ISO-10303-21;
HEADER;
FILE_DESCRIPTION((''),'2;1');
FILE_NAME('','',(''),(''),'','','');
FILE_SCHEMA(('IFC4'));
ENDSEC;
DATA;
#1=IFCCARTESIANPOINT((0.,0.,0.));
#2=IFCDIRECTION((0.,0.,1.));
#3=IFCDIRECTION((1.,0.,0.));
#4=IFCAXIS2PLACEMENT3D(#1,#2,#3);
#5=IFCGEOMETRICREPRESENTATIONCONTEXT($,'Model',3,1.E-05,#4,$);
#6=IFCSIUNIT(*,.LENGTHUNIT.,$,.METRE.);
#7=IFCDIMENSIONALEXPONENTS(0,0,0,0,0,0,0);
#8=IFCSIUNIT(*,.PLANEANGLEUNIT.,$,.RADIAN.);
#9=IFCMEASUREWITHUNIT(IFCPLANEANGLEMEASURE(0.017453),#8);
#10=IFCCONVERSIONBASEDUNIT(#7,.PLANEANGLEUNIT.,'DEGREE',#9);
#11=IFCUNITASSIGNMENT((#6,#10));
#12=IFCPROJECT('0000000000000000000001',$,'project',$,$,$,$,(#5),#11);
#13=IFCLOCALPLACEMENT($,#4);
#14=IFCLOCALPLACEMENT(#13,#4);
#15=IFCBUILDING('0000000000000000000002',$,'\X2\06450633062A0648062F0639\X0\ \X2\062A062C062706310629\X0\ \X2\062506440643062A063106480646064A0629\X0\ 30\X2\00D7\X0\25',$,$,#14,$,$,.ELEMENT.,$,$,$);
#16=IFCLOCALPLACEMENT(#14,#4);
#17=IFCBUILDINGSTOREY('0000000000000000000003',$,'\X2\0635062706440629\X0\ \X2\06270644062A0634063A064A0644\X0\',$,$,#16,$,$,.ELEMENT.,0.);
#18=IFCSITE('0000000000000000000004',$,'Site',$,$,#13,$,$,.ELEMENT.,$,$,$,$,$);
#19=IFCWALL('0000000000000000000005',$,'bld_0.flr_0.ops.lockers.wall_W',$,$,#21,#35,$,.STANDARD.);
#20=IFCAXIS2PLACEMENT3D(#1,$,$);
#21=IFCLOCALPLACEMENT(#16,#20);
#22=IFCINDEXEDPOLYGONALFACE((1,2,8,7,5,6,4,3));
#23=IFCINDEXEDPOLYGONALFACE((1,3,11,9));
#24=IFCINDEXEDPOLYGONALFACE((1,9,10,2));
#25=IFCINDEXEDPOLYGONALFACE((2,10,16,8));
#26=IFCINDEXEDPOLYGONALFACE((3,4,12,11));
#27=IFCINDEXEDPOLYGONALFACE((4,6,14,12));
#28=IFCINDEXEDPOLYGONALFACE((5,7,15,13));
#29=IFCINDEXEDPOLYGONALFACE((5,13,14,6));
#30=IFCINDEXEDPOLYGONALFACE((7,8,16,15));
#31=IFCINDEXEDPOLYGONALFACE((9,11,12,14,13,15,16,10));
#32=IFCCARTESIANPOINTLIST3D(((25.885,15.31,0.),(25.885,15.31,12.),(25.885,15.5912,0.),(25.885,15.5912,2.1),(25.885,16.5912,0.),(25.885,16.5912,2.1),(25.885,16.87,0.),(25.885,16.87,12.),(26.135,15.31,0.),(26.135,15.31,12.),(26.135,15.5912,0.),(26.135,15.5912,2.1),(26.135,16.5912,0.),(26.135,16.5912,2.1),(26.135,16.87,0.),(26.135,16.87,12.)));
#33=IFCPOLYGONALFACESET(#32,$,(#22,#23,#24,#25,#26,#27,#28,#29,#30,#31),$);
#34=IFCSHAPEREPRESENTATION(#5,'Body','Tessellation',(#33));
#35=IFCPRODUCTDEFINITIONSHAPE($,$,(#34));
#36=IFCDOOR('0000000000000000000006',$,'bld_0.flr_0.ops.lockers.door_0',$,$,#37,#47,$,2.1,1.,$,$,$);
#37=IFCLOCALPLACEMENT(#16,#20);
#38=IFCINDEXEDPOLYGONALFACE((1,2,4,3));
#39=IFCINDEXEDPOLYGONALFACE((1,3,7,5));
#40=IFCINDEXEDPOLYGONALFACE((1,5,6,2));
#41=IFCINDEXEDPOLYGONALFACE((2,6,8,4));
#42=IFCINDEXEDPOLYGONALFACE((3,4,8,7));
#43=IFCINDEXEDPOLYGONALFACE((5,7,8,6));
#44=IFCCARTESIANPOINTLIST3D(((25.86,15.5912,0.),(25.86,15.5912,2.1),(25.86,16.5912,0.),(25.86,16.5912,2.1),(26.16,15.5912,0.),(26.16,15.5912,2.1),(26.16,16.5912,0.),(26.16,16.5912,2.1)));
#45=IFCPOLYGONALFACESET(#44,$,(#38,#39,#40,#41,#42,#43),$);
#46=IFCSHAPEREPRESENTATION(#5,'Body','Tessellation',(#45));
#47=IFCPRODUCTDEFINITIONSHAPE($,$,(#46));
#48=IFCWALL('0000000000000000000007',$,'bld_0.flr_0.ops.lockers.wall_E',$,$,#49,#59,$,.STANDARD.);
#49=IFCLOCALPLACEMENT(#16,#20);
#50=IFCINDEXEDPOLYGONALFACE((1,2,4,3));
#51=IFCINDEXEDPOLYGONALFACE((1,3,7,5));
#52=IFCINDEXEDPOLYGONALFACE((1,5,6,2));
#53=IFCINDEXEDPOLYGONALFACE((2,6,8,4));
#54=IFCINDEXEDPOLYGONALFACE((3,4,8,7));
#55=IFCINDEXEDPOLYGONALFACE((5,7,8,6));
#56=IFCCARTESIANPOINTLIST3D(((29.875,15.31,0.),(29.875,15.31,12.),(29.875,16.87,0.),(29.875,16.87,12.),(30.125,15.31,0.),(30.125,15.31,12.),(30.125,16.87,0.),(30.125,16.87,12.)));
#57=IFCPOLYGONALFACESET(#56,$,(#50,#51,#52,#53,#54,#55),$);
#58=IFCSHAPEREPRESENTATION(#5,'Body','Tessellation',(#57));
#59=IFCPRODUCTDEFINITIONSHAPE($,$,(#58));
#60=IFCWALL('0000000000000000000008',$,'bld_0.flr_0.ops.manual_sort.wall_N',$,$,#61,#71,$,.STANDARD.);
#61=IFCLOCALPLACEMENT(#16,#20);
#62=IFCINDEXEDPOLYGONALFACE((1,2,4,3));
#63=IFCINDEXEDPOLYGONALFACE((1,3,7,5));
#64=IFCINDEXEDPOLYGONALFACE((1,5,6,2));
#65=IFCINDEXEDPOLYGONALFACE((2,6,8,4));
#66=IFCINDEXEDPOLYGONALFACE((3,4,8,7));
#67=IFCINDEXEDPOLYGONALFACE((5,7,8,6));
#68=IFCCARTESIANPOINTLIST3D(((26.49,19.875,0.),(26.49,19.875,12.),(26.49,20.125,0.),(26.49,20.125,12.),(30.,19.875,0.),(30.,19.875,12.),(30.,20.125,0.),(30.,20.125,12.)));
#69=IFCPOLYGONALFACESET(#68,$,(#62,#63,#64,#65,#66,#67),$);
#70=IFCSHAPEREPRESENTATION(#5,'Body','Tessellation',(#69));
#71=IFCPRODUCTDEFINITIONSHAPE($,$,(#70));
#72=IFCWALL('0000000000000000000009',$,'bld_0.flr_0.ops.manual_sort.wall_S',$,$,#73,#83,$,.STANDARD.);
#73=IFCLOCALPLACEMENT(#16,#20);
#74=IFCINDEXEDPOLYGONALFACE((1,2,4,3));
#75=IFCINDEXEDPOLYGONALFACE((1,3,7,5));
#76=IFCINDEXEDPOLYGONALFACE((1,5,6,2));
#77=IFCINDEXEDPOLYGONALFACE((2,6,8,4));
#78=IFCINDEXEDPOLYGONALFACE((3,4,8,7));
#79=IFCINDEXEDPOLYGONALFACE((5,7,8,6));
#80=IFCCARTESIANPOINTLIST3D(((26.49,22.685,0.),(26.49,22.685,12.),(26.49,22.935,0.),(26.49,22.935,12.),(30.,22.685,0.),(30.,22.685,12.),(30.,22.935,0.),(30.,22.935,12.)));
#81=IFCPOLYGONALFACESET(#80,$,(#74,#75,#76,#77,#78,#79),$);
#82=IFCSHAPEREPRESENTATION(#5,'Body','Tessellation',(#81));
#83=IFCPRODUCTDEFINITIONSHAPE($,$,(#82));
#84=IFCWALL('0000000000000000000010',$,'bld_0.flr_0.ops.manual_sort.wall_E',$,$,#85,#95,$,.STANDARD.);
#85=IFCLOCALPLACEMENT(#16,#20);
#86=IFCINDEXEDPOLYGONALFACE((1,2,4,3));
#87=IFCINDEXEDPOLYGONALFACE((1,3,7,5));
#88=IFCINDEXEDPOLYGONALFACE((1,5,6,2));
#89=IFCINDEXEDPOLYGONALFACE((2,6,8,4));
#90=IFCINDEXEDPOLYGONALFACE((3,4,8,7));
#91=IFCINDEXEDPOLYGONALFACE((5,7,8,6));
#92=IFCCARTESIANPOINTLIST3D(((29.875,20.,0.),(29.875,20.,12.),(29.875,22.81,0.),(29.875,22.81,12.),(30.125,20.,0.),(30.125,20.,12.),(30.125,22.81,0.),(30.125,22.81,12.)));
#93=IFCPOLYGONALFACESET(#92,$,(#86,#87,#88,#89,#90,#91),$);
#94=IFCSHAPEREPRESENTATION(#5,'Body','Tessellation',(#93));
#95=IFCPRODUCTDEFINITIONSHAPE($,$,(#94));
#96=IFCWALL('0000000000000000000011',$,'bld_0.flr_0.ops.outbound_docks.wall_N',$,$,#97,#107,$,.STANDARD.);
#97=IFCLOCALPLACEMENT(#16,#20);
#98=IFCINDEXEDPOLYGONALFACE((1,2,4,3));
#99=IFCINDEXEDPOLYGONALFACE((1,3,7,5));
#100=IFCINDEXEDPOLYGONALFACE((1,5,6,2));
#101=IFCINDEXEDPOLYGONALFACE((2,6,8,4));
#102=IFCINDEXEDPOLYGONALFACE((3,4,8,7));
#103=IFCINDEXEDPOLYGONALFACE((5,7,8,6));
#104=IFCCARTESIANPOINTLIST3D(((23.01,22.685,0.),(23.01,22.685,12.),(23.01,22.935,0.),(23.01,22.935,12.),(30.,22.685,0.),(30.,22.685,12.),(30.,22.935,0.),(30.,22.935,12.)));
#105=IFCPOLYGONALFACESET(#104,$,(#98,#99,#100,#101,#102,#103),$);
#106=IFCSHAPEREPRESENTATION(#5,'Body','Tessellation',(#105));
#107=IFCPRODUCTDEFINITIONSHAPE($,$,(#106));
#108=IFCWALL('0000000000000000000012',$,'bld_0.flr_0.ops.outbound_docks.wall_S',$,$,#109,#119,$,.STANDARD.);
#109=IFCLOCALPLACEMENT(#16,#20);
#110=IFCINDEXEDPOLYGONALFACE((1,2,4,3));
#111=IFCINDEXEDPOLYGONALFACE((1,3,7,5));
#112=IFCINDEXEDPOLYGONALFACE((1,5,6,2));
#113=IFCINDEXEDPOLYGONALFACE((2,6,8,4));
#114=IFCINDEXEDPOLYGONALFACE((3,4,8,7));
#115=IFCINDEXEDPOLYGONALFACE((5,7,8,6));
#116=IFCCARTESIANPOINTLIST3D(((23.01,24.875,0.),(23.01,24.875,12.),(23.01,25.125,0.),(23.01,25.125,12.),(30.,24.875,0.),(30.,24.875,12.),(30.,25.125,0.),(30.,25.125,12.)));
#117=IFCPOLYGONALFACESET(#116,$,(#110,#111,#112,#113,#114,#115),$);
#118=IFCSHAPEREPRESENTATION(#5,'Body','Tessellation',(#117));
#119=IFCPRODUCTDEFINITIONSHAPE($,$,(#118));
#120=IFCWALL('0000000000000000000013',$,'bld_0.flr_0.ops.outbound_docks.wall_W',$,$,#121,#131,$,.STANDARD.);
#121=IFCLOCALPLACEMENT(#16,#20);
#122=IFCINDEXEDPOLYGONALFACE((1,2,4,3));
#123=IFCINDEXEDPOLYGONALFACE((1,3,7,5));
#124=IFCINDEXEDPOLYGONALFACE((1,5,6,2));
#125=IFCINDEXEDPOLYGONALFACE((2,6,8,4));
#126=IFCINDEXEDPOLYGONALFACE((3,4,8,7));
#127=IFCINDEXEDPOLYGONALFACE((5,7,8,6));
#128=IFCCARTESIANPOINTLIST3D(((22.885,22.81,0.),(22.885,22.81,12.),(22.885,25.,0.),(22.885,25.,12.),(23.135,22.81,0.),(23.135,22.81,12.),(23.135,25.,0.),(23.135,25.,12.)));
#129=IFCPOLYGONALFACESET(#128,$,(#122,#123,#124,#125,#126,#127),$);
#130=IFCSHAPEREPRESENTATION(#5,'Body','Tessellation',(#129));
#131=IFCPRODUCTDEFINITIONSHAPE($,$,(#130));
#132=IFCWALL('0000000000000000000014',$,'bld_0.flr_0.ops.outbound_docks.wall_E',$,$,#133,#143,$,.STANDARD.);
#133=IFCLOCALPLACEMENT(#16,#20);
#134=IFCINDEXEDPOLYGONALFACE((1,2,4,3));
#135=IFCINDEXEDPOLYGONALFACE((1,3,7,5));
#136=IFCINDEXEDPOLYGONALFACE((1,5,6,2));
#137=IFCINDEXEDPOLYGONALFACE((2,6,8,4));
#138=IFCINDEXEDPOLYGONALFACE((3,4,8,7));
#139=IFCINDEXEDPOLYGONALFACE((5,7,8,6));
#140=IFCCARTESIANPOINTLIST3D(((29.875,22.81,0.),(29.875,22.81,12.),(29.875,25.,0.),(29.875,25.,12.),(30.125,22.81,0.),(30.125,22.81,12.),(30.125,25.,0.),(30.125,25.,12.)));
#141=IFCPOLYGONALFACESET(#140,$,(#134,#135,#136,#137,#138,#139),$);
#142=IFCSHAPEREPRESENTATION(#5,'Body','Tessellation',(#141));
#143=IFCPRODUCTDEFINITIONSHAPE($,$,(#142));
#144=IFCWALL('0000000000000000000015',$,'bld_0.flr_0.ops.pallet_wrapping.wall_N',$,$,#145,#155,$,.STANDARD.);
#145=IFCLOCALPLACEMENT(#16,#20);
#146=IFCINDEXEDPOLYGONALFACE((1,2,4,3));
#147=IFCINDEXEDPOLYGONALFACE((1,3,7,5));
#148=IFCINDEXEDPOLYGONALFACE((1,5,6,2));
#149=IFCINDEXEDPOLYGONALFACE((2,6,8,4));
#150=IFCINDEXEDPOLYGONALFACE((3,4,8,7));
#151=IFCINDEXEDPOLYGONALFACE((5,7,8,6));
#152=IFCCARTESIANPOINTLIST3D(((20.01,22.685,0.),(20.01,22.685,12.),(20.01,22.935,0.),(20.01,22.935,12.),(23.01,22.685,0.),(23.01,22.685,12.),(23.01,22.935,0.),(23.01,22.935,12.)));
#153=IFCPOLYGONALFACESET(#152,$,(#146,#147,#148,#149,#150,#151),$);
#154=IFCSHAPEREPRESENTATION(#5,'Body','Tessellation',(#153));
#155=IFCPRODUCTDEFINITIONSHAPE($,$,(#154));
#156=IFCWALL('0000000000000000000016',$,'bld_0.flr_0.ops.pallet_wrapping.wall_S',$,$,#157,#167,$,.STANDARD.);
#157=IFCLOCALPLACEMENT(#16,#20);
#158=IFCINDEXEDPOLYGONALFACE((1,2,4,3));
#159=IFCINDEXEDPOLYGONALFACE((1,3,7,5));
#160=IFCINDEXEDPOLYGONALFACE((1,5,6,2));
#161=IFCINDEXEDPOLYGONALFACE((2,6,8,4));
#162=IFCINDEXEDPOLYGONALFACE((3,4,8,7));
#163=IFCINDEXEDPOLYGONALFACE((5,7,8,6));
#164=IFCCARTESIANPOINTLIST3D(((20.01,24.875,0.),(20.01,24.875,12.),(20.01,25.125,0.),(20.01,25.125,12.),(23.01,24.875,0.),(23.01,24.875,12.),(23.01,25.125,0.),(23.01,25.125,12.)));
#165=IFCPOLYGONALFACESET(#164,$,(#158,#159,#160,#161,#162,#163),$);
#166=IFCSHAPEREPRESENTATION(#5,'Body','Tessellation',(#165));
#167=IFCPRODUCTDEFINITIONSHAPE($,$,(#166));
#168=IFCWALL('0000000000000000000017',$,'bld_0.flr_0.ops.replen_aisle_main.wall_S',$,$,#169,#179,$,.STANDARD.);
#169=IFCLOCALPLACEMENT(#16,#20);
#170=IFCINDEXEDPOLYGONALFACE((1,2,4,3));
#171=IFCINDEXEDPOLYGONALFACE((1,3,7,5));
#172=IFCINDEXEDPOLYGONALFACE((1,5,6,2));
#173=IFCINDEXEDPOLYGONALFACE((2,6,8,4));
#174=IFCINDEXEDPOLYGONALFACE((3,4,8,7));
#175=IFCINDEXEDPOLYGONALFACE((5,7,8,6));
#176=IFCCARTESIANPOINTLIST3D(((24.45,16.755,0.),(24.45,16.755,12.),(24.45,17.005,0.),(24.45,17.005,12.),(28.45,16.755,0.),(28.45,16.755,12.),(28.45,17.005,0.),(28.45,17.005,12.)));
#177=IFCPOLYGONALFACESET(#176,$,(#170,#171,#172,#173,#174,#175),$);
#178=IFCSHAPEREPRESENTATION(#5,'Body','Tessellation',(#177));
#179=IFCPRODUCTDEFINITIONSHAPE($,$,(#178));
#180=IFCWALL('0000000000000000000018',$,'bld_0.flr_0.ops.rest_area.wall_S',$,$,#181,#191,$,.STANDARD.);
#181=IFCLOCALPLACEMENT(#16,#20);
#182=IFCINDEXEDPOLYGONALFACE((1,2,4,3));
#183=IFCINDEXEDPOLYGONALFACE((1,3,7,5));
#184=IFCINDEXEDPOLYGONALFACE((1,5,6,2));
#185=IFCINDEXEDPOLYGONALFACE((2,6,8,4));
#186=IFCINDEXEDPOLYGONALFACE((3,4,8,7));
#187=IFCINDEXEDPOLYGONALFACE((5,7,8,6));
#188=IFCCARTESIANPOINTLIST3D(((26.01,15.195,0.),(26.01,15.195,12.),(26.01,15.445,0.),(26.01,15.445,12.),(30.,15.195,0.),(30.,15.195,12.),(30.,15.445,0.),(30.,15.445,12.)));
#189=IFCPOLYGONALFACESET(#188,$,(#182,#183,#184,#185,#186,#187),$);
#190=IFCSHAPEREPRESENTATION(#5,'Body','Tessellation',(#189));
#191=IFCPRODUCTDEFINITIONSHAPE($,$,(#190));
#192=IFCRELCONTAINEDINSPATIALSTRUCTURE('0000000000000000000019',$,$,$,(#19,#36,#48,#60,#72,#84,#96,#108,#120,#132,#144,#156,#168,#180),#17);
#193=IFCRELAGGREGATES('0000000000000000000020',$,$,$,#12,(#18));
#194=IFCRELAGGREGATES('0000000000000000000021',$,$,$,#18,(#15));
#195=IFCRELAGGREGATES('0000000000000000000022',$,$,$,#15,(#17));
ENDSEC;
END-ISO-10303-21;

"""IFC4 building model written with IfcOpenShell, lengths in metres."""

from ifc_helpers import new_model, entity, si_unit, converted_unit, frame, frame_2d, origin_with_axes, origin_2d_with_axis, place, context, project, spatial, rectangle, extrude, element, fill, save


model = new_model("IFC4")

# Units and contexts
model_context = context("Model", 3, precision=1e-05, world=origin_with_axes())
ifc_project = project(units=[si_unit("LENGTHUNIT", "METRE"), converted_unit("PLANEANGLEUNIT", "DEGREE", entity("IfcPlaneAngleMeasure", 0.017453), si_unit("PLANEANGLEUNIT", "RADIAN"), dimensions=[0, 0, 0, 0, 0, 0, 0])], contexts=[model_context])

# Site, building, storey
site_placement = place(None, origin_with_axes())
site = spatial("IfcSite", under=ifc_project, at=site_placement, Name="Site", CompositionType="ELEMENT")
building_placement = place(site_placement, origin_with_axes())
building = spatial("IfcBuilding", under=site, at=building_placement, Name="مستودع تجارة إلكترونية 30×25", CompositionType="ELEMENT")
storey_placement = place(building_placement, origin_with_axes())
storey = spatial("IfcBuildingStorey", under=building, at=storey_placement, Name="صالة التشغيل", CompositionType="ELEMENT", Elevation=0.0)

# Wall, opening, door
wall_1_placement = place(storey_placement, frame((26.01, 15.31, 0.0), z_axis=(0.0, 0.0, 1.0), x_axis=(0.0, 1.0, 0.0)))
wall_1 = element("IfcWall", 1, at=wall_1_placement, inside=storey, Name="bld_0.flr_0.ops.lockers.wall_W", PredefinedType="STANDARD", context=model_context, shape_type="SweptSolid", body=[
    extrude(rectangle(XDim=1.56, YDim=0.25, at=frame_2d((0.78, 0.0), x_axis=(1.0, 0.0))), origin_with_axes(), (0.0, 0.0, 1.0), 12.0),
])
opening_1_placement = place(storey_placement, frame((26.01, 16.0912, 0.0), z_axis=(0.0, 0.0, 1.0), x_axis=(0.0, 1.0, 0.0)))
opening_1 = element("IfcOpeningElement", 2, at=opening_1_placement, cuts=wall_1, PredefinedType="OPENING", context=model_context, shape_type="SweptSolid", body=[
    extrude(rectangle(XDim=1.0, YDim=0.3, at=origin_2d_with_axis()), origin_with_axes(), (0.0, 0.0, 1.0), 2.1),
])
door_1_placement = place(storey_placement, frame((26.01, 16.0912, 0.0), z_axis=(0.0, 0.0, 1.0), x_axis=(0.0, 1.0, 0.0)))
door_1 = element("IfcDoor", 3, at=door_1_placement, inside=storey, Name="bld_0.flr_0.ops.lockers.door_0", OverallHeight=2.1, OverallWidth=1.0, context=model_context, shape_type="SweptSolid", body=[
    extrude(rectangle(XDim=1.0, YDim=0.3, at=origin_2d_with_axis()), origin_with_axes(), (0.0, 0.0, 1.0), 2.1),
])
fill(opening_1, door_1)

# Walls
wall_2_placement = place(storey_placement, frame((30.0, 15.31, 0.0), z_axis=(0.0, 0.0, 1.0), x_axis=(0.0, 1.0, 0.0)))
element("IfcWall", 4, at=wall_2_placement, inside=storey, Name="bld_0.flr_0.ops.lockers.wall_E", PredefinedType="STANDARD", context=model_context, shape_type="SweptSolid", body=[
    extrude(rectangle(XDim=1.56, YDim=0.25, at=frame_2d((0.78, 0.0), x_axis=(1.0, 0.0))), origin_with_axes(), (0.0, 0.0, 1.0), 12.0),
])
for number, where, z_axis, x_axis, name in (
    (5, (26.49, 20.0, 0.0), (0.0, 0.0, 1.0), (1.0, 0.0, 0.0), "bld_0.flr_0.ops.manual_sort.wall_N"),
    (6, (26.49, 22.81, 0.0), (0.0, 0.0, 1.0), (1.0, 0.0, 0.0), "bld_0.flr_0.ops.manual_sort.wall_S"),
):
    element("IfcWall", number, at=place(storey_placement, frame(where, z_axis=z_axis, x_axis=x_axis)), inside=storey, Name=name, PredefinedType="STANDARD", context=model_context, shape_type="SweptSolid", body=[
        extrude(rectangle(XDim=3.51, YDim=0.25, at=frame_2d((1.755, 0.0), x_axis=(1.0, 0.0))), origin_with_axes(), (0.0, 0.0, 1.0), 12.0),
    ])
for number, where, z_axis, x_axis, name in (
    (7, (30.0, 20.0, 0.0), (0.0, 0.0, 1.0), (0.0, 1.0, 0.0), "bld_0.flr_0.ops.manual_sort.wall_E"),
):
    element("IfcWall", number, at=place(storey_placement, frame(where, z_axis=z_axis, x_axis=x_axis)), inside=storey, Name=name, PredefinedType="STANDARD", context=model_context, shape_type="SweptSolid", body=[
        extrude(rectangle(XDim=2.81, YDim=0.25, at=frame_2d((1.405, 0.0), x_axis=(1.0, 0.0))), origin_with_axes(), (0.0, 0.0, 1.0), 12.0),
    ])
for number, where, z_axis, x_axis, name in (
    (8, (23.01, 22.81, 0.0), (0.0, 0.0, 1.0), (1.0, 0.0, 0.0), "bld_0.flr_0.ops.outbound_docks.wall_N"),
    (9, (23.01, 25.0, 0.0), (0.0, 0.0, 1.0), (1.0, 0.0, 0.0), "bld_0.flr_0.ops.outbound_docks.wall_S"),
):
    element("IfcWall", number, at=place(storey_placement, frame(where, z_axis=z_axis, x_axis=x_axis)), inside=storey, Name=name, PredefinedType="STANDARD", context=model_context, shape_type="SweptSolid", body=[
        extrude(rectangle(XDim=6.99, YDim=0.25, at=frame_2d((3.495, 0.0), x_axis=(1.0, 0.0))), origin_with_axes(), (0.0, 0.0, 1.0), 12.0),
    ])
for number, where, z_axis, x_axis, name in (
    (10, (23.01, 22.81, 0.0), (0.0, 0.0, 1.0), (0.0, 1.0, 0.0), "bld_0.flr_0.ops.outbound_docks.wall_W"),
    (11, (30.0, 22.81, 0.0), (0.0, 0.0, 1.0), (0.0, 1.0, 0.0), "bld_0.flr_0.ops.outbound_docks.wall_E"),
):
    element("IfcWall", number, at=place(storey_placement, frame(where, z_axis=z_axis, x_axis=x_axis)), inside=storey, Name=name, PredefinedType="STANDARD", context=model_context, shape_type="SweptSolid", body=[
        extrude(rectangle(XDim=2.19, YDim=0.25, at=frame_2d((1.095, 0.0), x_axis=(1.0, 0.0))), origin_with_axes(), (0.0, 0.0, 1.0), 12.0),
    ])
for number, where, z_axis, x_axis, name in (
    (12, (20.01, 22.81, 0.0), (0.0, 0.0, 1.0), (1.0, 0.0, 0.0), "bld_0.flr_0.ops.pallet_wrapping.wall_N"),
    (13, (20.01, 25.0, 0.0), (0.0, 0.0, 1.0), (1.0, 0.0, 0.0), "bld_0.flr_0.ops.pallet_wrapping.wall_S"),
):
    element("IfcWall", number, at=place(storey_placement, frame(where, z_axis=z_axis, x_axis=x_axis)), inside=storey, Name=name, PredefinedType="STANDARD", context=model_context, shape_type="SweptSolid", body=[
        extrude(rectangle(XDim=3.0, YDim=0.25, at=frame_2d((1.5, 0.0), x_axis=(1.0, 0.0))), origin_with_axes(), (0.0, 0.0, 1.0), 12.0),
    ])
wall_3_placement = place(storey_placement, frame((24.45, 16.88, 0.0), z_axis=(0.0, 0.0, 1.0), x_axis=(1.0, 0.0, 0.0)))
element("IfcWall", 14, at=wall_3_placement, inside=storey, Name="bld_0.flr_0.ops.replen_aisle_main.wall_S", PredefinedType="STANDARD", context=model_context, shape_type="SweptSolid", body=[
    extrude(rectangle(XDim=4.0, YDim=0.25, at=frame_2d((2.0, 0.0), x_axis=(1.0, 0.0))), origin_with_axes(), (0.0, 0.0, 1.0), 12.0),
])
wall_4_placement = place(storey_placement, frame((26.01, 15.32, 0.0), z_axis=(0.0, 0.0, 1.0), x_axis=(1.0, 0.0, 0.0)))
element("IfcWall", 15, at=wall_4_placement, inside=storey, Name="bld_0.flr_0.ops.rest_area.wall_S", PredefinedType="STANDARD", context=model_context, shape_type="SweptSolid", body=[
    extrude(rectangle(XDim=3.99, YDim=0.25, at=frame_2d((1.995, 0.0), x_axis=(1.0, 0.0))), origin_with_axes(), (0.0, 0.0, 1.0), 12.0),
])

save(model, "model.ifc")
